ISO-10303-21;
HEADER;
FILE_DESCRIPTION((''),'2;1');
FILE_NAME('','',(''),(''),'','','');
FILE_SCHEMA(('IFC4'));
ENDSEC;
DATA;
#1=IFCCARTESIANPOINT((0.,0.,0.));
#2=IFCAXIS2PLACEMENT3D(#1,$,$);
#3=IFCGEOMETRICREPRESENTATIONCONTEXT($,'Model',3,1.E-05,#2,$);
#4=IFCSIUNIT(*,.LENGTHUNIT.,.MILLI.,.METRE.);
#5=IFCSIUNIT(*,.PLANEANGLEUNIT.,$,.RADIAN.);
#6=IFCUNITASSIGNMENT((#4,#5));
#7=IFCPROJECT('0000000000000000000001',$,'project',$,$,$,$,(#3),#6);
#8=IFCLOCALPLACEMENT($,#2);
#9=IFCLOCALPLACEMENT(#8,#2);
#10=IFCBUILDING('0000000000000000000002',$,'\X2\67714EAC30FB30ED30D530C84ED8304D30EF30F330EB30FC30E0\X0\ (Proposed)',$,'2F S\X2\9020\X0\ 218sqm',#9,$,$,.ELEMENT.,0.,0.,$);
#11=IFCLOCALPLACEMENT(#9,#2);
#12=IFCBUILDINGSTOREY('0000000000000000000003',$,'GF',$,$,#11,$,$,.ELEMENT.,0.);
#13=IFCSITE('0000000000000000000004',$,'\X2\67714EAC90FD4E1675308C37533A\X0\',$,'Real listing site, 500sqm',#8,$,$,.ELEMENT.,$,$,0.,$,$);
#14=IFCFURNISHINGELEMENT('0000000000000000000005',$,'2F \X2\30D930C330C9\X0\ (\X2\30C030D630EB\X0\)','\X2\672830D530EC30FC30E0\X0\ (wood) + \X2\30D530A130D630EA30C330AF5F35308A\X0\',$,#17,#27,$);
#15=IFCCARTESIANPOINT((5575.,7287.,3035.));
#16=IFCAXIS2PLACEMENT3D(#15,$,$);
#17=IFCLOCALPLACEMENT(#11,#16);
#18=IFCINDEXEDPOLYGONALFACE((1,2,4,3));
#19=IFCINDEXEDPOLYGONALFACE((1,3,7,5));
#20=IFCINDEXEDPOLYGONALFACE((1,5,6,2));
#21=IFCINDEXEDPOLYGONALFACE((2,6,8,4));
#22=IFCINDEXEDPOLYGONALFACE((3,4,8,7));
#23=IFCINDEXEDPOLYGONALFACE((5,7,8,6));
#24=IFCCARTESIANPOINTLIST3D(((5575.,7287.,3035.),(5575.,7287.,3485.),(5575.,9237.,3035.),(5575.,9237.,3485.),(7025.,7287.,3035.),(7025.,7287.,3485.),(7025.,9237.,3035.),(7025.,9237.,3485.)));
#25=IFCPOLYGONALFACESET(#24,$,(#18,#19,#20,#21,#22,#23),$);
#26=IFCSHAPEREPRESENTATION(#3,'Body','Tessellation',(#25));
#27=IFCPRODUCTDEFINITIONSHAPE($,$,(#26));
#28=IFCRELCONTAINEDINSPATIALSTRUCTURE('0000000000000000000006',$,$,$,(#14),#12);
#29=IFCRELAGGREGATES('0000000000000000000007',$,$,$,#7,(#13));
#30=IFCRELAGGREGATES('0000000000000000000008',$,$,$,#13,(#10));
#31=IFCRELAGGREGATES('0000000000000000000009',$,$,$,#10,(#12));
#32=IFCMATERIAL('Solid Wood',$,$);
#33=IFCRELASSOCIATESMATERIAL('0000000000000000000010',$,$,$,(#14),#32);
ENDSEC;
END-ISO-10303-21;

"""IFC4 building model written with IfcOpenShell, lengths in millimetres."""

from ifc_helpers import new_model, si_unit, frame, frame_2d, origin, place, context, project, spatial, rectangle, extrude, material, element, save


model = new_model("IFC4")

# Units and contexts
model_context = context("Model", 3, precision=1e-05, world=origin())
ifc_project = project(units=[si_unit("LENGTHUNIT", "METRE", prefix="MILLI"), si_unit("PLANEANGLEUNIT", "RADIAN")], contexts=[model_context])

# Site, building, storey
site_placement = place(None, origin())
site = spatial("IfcSite", under=ifc_project, at=site_placement, Name="東京都世田谷区", ObjectType="Real listing site, 500sqm", CompositionType="ELEMENT", RefElevation=0.0)
building_placement = place(site_placement, origin())
building = spatial("IfcBuilding", under=site, at=building_placement, Name="東京・ロフト付きワンルーム (Proposed)", ObjectType="2F S造 218sqm", CompositionType="ELEMENT", ElevationOfRefHeight=0.0, ElevationOfTerrain=0.0)
storey_placement = place(building_placement, origin())
storey = spatial("IfcBuildingStorey", under=building, at=storey_placement, Name="GF", CompositionType="ELEMENT", Elevation=0.0)

# Shared definitions
ifc_material_1 = material(Name="Solid Wood")

# Furnishing element
furnishing_1_placement = place(storey_placement, frame((5575.0, 7287.0, 3035.0)))
element("IfcFurnishingElement", 1, at=furnishing_1_placement, inside=storey, material=ifc_material_1, Name="2F ベッド (ダブル)", Description="木フレーム (wood) + ファブリック張り", context=model_context, shape_type="SweptSolid", body=[
    extrude(rectangle(XDim=1450.0, YDim=1950.0, at=frame_2d((725.0, 975.0))), frame((5575.0, 7287.0, 3035.0)), (0.0, 0.0, 1.0), 450.0),
])

save(model, "model.ifc")
